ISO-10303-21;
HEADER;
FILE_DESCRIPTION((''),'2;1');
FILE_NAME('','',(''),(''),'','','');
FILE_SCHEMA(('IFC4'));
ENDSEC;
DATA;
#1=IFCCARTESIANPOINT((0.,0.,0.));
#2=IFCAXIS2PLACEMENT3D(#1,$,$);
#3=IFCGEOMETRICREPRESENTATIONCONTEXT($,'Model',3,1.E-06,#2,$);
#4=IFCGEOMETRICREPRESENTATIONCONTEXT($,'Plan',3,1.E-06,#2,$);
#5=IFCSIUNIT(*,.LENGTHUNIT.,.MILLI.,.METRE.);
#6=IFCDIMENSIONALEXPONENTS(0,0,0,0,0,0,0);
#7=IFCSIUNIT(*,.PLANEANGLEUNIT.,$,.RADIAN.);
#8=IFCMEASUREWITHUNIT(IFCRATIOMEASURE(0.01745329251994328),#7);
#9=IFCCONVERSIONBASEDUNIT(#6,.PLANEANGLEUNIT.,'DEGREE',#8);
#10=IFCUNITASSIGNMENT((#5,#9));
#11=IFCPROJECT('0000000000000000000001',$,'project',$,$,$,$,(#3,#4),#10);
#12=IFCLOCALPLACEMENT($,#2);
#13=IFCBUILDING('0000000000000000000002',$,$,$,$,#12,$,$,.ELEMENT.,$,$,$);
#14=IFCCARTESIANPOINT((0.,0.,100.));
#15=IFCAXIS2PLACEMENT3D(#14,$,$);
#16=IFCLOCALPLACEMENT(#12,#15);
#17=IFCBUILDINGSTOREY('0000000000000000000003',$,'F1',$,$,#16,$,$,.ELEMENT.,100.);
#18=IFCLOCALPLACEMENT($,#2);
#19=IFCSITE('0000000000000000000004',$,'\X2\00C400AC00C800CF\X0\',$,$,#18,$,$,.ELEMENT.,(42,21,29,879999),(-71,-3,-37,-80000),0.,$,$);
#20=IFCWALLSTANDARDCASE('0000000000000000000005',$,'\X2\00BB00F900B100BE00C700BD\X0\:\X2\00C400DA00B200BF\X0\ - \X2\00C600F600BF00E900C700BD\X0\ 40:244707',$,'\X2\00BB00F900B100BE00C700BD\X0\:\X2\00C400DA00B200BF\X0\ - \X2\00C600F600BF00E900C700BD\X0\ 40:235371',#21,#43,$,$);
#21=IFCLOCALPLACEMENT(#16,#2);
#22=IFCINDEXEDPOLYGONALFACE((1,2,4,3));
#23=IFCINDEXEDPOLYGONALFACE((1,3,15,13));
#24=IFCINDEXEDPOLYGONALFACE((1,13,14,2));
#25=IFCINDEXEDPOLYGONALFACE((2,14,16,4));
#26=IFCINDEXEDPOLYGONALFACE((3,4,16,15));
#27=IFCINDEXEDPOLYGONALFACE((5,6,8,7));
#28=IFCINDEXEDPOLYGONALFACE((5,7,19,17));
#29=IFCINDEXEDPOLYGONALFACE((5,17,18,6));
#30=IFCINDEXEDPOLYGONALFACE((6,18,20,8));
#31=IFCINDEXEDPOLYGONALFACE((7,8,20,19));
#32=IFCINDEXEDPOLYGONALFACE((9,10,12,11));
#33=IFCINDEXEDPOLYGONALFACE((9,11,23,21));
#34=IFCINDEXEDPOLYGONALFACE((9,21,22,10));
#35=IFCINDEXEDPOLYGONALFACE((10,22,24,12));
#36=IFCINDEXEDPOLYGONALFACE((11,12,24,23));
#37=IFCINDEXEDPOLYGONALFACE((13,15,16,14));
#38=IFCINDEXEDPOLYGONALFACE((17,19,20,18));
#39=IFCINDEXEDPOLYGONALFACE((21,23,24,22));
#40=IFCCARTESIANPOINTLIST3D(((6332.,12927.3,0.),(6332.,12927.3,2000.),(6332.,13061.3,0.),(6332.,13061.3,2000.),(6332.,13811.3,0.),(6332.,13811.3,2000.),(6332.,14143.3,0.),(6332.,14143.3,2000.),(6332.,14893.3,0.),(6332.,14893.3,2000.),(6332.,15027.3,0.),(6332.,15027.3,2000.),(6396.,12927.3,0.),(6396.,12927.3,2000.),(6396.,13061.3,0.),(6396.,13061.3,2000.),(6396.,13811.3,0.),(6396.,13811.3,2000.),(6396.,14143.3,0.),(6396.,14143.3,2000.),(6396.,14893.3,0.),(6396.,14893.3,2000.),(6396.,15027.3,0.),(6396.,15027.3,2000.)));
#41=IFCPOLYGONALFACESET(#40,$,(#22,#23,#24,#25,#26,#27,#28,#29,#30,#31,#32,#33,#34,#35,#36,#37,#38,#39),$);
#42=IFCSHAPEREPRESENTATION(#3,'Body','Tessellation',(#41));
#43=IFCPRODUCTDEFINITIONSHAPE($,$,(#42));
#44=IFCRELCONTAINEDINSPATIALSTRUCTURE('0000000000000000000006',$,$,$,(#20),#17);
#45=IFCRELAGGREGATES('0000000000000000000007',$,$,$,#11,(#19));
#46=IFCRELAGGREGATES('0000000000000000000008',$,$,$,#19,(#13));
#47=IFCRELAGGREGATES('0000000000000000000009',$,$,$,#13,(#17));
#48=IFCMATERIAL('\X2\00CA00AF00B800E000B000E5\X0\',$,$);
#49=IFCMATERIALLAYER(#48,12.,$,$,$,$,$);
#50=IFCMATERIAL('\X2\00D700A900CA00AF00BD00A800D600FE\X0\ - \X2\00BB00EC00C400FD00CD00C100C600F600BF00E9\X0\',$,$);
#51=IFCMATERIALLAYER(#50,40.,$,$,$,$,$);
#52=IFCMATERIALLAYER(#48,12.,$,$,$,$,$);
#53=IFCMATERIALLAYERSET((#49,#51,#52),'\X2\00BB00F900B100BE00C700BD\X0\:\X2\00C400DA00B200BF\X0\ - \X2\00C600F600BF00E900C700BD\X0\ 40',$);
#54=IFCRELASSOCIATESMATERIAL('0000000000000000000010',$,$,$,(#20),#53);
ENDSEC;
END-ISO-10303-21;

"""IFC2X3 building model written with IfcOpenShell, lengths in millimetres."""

from ifc_helpers import new_model, entity, si_unit, converted_unit, frame, frame_2d, origin, place, context, project, spatial, rectangle, extrude, material, layer, layer_set, layer_usage, element, save


model = new_model("IFC2X3")

# Units and contexts
model_context = context("Model", 3, precision=1e-06, world=origin())
plan_context = context("Plan", 3, precision=1e-06, world=origin())
ifc_project = project(units=[si_unit("LENGTHUNIT", "METRE", prefix="MILLI"), converted_unit("PLANEANGLEUNIT", "DEGREE", entity("IfcRatioMeasure", 0.01745329251994328), si_unit("PLANEANGLEUNIT", "RADIAN"), dimensions=[0, 0, 0, 0, 0, 0, 0])], contexts=[model_context, plan_context])

# Site, building, storey
site_placement = place(None, origin())
site = spatial("IfcSite", under=ifc_project, at=site_placement, Name="Ä¬ÈÏ", CompositionType="ELEMENT", RefLatitude=(42, 21, 29, 879999), RefLongitude=(-71, -3, -37, -80000), RefElevation=0.0)
building_placement = place(None, origin())
building = spatial("IfcBuilding", under=site, at=building_placement, CompositionType="ELEMENT")
storey_placement = place(building_placement, frame((0.0, 0.0, 100.0)))
storey = spatial("IfcBuildingStorey", under=building, at=storey_placement, Name="F1", CompositionType="ELEMENT", Elevation=100.0)

# Shared definitions
ifc_material_1 = material(Name="×©Ê¯½¨Öþ - »ìÄýÍÁÆö¿é")

# Wall, openings
ifc_material_2 = material(Name="Ê¯¸à°å")
ifc_layer_1 = layer(ifc_material_2, 12.0)
ifc_layer_2 = layer(ifc_material_1, 40.0)
ifc_layer_3 = layer(ifc_material_2, 12.0)
ifc_layer_set_1 = layer_set([ifc_layer_1, ifc_layer_2, ifc_layer_3], Name="»ù±¾Ç½:ÄÚ²¿ - Æö¿éÇ½ 40")
ifc_layer_usage_1 = layer_usage(ifc_layer_set_1, "AXIS2", "POSITIVE", -32.0)
wall_1_placement = place(storey_placement, frame((6364.0, 15027.3, 0.0), z_axis=(0.0, 0.0, 1.0), x_axis=(0.0, -1.0, 0.0)))
wall_1 = element("IfcWallStandardCase", 1, at=wall_1_placement, inside=storey, material=ifc_layer_usage_1, Name="»ù±¾Ç½:ÄÚ²¿ - Æö¿éÇ½ 40:244707", ObjectType="»ù±¾Ç½:ÄÚ²¿ - Æö¿éÇ½ 40:235371", context=model_context, shape_type="SweptSolid", body=[
    extrude(rectangle(XDim=2100.0, YDim=64.0, at=frame_2d((1050.0, 0.0), x_axis=(-1.0, 0.0))), origin(), (0.0, 0.0, 1.0), 2000.0),
])
opening_1_placement = place(wall_1_placement, frame((884.0, 32.0, 0.0)))
element("IfcOpeningElement", 2, at=opening_1_placement, cuts=wall_1, ObjectType="Opening", context=model_context, shape_type="SweptSolid", body=[
    extrude(rectangle(XDim=2000.0, YDim=750.0, at=frame_2d((1000.0, 375.0), x_axis=(1.0, 0.0))), frame((0.0, 0.0, 0.0), z_axis=(0.0, -1.0, 0.0), x_axis=(0.0, 0.0, 1.0)), (0.0, 0.0, 1.0), 64.0),
])
opening_2_placement = place(wall_1_placement, frame((1966.0, 32.0, 0.0)))
element("IfcOpeningElement", 3, at=opening_2_placement, cuts=wall_1, ObjectType="Opening", context=model_context, shape_type="SweptSolid", body=[
    extrude(rectangle(XDim=2000.0, YDim=750.0, at=frame_2d((1000.0, 375.0), x_axis=(1.0, 0.0))), frame((0.0, 0.0, 0.0), z_axis=(0.0, -1.0, 0.0), x_axis=(0.0, 0.0, 1.0)), (0.0, 0.0, 1.0), 64.0),
])

save(model, "model.ifc")
